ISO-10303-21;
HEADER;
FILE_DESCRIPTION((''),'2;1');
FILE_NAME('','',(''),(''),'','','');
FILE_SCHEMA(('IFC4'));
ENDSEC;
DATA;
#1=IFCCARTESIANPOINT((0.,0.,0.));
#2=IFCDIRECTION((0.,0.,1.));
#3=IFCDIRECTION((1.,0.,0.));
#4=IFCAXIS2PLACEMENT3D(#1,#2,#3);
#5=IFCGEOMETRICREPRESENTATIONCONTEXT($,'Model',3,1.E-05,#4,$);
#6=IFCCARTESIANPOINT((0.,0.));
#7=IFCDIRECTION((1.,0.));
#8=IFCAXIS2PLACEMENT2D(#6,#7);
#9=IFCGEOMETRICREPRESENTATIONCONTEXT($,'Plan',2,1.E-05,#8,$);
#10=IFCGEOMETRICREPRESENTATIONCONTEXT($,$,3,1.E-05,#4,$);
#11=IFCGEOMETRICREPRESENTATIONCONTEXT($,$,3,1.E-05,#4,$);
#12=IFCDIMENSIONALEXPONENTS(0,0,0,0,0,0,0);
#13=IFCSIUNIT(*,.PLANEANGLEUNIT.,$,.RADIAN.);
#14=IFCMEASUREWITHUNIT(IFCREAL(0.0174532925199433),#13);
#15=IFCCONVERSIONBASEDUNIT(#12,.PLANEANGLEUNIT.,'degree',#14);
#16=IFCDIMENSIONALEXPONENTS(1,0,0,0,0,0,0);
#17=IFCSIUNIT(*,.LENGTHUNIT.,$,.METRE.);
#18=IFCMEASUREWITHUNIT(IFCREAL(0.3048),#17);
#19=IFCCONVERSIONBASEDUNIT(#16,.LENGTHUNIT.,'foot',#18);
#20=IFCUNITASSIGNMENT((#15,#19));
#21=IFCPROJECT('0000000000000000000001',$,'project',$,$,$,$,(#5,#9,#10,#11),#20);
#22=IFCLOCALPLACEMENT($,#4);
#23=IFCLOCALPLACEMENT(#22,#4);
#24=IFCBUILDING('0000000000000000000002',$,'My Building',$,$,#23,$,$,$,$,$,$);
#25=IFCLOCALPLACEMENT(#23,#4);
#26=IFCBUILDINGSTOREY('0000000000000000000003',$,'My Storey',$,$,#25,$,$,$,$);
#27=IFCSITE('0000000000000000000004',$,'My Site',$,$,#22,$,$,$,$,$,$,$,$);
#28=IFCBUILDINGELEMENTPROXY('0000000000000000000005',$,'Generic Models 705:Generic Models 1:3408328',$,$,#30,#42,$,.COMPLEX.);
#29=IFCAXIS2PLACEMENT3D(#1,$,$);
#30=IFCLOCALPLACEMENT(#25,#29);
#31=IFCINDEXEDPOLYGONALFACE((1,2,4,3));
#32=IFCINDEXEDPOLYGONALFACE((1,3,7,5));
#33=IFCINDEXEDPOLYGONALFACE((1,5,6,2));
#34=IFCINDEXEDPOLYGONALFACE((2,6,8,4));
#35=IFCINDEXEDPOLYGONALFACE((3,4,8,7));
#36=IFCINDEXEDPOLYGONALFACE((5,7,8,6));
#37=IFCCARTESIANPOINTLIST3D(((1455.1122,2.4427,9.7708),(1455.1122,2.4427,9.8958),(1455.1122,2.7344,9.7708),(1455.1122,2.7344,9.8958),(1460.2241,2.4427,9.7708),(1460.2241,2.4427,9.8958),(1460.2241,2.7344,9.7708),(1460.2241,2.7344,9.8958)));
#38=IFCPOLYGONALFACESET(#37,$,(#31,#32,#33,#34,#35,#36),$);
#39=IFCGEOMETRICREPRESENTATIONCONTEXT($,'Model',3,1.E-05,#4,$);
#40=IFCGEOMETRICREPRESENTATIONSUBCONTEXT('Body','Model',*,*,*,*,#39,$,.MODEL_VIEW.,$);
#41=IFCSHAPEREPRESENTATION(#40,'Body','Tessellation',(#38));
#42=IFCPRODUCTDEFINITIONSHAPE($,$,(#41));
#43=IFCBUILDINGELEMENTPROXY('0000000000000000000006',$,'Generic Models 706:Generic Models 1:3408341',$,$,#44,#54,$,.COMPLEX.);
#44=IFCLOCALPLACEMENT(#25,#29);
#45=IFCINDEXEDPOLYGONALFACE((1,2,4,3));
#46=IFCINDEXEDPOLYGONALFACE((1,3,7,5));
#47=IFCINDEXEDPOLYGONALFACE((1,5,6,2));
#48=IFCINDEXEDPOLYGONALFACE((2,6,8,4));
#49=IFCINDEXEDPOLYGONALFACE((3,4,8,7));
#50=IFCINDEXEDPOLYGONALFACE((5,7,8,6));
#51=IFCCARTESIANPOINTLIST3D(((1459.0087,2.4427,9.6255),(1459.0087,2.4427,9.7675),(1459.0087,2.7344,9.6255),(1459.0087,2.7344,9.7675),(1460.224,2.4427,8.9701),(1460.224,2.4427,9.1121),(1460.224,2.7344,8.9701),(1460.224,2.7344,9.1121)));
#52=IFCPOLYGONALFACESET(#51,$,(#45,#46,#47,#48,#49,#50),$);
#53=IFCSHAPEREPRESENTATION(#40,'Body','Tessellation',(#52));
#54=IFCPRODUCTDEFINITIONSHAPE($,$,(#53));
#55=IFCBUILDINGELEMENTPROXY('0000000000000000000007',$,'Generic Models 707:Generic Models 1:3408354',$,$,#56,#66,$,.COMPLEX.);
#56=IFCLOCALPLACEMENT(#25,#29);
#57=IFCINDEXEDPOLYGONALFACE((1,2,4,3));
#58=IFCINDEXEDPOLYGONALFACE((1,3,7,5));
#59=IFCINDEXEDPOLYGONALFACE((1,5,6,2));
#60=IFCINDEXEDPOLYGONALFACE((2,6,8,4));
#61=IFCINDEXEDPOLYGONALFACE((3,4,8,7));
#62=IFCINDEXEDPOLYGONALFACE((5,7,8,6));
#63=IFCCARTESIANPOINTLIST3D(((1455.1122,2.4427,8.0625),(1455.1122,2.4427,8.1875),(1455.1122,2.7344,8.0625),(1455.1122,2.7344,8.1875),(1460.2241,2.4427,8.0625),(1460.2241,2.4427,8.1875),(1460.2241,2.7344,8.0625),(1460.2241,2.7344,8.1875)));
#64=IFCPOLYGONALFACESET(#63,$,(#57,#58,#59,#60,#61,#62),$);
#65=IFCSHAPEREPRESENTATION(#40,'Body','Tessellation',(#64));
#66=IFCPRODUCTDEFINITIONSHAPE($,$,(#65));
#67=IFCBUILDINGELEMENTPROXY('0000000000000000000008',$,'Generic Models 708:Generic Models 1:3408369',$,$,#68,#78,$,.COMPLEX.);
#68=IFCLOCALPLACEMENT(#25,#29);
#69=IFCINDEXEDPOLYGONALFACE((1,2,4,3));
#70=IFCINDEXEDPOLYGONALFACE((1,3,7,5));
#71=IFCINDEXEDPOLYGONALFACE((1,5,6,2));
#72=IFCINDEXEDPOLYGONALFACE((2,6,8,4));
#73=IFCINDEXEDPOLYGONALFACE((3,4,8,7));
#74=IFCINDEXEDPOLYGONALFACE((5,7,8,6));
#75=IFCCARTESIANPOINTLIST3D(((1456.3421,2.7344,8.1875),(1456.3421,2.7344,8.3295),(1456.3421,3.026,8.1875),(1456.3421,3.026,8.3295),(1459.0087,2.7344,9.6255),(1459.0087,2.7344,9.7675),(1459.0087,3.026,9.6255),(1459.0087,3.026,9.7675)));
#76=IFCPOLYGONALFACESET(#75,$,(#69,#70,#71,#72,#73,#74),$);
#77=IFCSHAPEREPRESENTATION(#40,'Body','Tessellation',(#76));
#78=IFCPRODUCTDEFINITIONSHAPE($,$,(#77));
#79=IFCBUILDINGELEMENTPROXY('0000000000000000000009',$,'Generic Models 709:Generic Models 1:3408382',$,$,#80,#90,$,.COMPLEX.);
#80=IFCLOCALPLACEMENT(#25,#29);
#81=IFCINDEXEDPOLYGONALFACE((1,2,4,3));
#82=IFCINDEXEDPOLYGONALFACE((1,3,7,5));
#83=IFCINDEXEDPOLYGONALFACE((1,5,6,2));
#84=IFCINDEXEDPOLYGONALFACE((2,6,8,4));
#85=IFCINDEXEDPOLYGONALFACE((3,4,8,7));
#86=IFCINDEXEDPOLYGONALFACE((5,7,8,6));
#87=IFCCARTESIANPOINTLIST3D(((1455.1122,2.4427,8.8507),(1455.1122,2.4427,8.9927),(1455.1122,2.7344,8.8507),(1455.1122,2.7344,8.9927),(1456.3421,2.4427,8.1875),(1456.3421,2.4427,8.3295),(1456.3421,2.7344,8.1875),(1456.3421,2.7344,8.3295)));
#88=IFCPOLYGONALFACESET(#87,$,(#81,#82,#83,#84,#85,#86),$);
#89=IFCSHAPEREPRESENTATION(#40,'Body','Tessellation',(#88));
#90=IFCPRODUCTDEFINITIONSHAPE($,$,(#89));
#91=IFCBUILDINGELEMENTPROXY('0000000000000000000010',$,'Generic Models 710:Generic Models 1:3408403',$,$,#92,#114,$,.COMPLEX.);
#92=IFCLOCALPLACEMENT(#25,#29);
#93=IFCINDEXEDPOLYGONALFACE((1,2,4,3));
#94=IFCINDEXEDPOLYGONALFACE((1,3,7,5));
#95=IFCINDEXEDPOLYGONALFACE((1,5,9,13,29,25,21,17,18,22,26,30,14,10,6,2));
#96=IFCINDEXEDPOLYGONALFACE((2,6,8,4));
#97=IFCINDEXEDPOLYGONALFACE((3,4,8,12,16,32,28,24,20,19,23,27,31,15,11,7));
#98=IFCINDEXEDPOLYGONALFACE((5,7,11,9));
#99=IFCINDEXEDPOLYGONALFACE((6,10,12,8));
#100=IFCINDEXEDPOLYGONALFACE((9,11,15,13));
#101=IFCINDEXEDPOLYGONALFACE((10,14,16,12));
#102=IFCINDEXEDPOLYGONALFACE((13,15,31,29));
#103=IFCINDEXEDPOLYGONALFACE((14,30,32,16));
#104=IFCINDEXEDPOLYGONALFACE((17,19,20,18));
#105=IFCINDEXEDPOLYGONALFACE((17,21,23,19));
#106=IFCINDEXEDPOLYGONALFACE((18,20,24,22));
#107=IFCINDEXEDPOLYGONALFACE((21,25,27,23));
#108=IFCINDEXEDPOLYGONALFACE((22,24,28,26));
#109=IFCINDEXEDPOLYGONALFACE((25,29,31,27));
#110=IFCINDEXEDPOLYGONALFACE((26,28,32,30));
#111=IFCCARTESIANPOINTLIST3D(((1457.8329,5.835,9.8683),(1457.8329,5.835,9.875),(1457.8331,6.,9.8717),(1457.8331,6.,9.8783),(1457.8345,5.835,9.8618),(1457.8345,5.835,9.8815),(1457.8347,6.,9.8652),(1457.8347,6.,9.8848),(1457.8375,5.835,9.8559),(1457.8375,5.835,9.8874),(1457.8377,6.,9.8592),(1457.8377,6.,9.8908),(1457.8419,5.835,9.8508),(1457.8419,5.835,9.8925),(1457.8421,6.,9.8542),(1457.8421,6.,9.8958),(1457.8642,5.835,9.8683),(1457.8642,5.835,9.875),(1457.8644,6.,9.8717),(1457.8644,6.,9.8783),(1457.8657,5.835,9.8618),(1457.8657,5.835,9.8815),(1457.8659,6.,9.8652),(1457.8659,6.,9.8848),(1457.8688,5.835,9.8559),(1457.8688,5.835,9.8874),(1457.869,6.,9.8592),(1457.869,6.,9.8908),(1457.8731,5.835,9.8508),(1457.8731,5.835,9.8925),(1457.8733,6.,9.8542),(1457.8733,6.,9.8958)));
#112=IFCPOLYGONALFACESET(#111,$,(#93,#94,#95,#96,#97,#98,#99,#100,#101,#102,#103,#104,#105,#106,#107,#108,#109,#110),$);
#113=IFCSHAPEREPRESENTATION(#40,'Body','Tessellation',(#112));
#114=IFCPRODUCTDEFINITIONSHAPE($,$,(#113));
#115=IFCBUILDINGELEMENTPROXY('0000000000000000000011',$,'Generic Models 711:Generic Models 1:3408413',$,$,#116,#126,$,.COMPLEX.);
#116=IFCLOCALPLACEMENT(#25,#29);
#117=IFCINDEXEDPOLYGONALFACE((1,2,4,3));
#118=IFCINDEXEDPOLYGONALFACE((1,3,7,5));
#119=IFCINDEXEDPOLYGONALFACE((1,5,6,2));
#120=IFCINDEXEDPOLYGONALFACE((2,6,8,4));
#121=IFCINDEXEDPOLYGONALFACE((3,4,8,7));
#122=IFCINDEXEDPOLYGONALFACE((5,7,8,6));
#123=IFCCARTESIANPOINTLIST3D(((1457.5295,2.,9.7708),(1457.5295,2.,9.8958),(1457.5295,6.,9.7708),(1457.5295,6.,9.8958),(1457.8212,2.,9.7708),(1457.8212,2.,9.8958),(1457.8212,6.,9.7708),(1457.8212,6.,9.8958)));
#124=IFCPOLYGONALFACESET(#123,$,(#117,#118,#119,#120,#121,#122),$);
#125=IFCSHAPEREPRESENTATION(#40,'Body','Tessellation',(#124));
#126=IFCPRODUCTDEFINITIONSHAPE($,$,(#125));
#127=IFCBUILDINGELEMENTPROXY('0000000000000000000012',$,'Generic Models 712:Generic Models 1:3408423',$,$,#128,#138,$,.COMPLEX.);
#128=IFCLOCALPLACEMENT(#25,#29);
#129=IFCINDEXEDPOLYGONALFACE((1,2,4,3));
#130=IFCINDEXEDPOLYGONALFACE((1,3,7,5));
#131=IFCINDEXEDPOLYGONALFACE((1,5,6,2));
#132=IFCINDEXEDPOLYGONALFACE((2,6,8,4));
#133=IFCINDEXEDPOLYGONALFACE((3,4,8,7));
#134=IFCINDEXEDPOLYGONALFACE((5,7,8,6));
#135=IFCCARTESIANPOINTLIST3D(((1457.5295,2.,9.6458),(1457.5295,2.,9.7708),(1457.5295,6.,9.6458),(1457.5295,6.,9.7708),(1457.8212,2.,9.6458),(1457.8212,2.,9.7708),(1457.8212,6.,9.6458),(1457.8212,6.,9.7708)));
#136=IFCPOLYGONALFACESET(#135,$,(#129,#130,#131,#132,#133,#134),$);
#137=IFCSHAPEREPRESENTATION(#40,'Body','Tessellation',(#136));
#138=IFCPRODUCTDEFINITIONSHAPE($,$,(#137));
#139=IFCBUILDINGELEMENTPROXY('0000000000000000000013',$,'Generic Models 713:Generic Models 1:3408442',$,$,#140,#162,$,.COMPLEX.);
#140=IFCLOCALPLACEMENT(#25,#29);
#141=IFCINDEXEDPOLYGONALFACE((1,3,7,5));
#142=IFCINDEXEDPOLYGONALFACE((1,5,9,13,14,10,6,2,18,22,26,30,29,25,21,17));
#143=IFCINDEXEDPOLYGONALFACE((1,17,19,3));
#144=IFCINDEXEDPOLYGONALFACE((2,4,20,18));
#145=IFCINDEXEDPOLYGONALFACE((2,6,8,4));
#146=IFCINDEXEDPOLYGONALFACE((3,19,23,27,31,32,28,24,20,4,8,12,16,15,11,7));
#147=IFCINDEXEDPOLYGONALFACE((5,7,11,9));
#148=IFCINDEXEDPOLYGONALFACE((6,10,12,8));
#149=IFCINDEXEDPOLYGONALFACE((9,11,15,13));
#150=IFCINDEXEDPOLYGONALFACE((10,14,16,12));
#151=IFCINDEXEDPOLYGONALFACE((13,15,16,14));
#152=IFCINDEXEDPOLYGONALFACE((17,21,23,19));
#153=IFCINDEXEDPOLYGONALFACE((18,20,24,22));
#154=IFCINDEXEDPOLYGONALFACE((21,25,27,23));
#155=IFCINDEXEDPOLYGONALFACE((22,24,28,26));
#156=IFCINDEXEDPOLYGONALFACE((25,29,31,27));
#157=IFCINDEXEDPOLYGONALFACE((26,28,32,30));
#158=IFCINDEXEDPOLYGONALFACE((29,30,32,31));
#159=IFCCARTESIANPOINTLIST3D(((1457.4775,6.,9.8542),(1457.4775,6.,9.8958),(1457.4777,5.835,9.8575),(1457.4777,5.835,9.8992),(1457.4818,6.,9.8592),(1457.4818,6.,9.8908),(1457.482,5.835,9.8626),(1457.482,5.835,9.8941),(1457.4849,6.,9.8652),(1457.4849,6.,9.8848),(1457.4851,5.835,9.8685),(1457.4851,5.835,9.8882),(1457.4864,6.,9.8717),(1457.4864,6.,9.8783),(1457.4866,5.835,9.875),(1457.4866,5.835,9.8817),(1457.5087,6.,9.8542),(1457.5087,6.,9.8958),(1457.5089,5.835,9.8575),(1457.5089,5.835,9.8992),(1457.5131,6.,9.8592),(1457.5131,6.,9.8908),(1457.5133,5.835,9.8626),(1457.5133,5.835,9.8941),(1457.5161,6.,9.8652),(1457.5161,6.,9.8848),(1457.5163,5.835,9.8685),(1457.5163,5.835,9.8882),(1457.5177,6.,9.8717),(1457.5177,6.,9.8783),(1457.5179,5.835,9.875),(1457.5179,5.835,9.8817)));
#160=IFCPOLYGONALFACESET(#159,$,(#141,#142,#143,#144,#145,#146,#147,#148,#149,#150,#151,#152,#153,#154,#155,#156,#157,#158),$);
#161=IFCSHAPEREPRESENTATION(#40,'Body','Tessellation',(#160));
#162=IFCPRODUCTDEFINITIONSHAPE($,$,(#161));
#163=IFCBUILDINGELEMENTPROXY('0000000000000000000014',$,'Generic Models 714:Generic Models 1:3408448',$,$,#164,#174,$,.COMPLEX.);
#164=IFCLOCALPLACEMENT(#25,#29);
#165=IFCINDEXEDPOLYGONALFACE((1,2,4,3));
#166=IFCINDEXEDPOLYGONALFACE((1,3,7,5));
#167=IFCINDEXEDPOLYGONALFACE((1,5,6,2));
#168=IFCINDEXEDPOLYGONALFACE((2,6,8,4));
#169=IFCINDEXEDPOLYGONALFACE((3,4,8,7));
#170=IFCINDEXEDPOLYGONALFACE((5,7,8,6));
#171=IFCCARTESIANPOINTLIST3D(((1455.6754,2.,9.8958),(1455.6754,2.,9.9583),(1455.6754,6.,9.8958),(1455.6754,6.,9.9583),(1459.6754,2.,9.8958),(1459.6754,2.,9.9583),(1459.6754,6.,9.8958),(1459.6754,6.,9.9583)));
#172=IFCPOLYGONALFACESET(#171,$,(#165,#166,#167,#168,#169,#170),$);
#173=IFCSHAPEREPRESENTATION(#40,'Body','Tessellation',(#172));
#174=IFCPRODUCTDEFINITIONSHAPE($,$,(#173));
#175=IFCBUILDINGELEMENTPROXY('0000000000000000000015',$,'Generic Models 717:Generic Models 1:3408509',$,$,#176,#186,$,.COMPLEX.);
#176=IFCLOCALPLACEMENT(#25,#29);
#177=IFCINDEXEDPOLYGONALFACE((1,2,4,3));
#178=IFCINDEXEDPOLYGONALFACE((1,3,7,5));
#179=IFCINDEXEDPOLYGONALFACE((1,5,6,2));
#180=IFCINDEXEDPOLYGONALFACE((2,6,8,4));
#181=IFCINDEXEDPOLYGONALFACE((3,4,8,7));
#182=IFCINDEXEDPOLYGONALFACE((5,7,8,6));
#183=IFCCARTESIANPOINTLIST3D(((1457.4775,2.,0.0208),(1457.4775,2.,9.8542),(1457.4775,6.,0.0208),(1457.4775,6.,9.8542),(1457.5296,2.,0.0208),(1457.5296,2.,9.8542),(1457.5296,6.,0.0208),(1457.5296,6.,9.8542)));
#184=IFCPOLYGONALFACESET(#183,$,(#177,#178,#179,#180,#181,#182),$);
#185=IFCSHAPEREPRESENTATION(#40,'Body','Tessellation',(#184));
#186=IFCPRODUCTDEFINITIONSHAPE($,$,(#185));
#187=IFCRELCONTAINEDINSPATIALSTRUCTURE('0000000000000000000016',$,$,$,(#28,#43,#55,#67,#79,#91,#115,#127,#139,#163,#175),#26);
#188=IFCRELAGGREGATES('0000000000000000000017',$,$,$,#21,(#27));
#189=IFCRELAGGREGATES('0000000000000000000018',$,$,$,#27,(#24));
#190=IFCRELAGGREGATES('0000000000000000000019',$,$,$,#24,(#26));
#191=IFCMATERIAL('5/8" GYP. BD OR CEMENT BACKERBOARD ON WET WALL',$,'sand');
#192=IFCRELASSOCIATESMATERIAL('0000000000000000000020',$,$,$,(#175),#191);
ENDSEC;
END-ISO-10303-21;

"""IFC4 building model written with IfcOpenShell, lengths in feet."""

from ifc_helpers import new_model, entity, si_unit, converted_unit, frame, origin_with_axes, origin_2d_with_axis, place, context, subcontext, project, spatial, polyline, outline, extrude, material, element, save


model = new_model("IFC4")

# Units and contexts
model_context_1 = context("Model", 3, precision=1e-05, world=origin_with_axes())
plan_context = context("Plan", 2, precision=1e-05, world=origin_2d_with_axis())
model_context_2 = context("Model", 3, precision=1e-05, world=origin_with_axes())
context_of_model_1 = context(None, 3, precision=1e-05, world=origin_with_axes())
context_of_model_2 = context(None, 3, precision=1e-05, world=origin_with_axes())
body_context = subcontext(model_context_2, "Body", "Model", "MODEL_VIEW")
ifc_project = project(units=[converted_unit("PLANEANGLEUNIT", "degree", entity("IfcReal", 0.0174532925199433), si_unit("PLANEANGLEUNIT", "RADIAN"), dimensions=[0, 0, 0, 0, 0, 0, 0]), converted_unit("LENGTHUNIT", "foot", entity("IfcReal", 0.3048), si_unit("LENGTHUNIT", "METRE"), dimensions=[1, 0, 0, 0, 0, 0, 0])], contexts=[model_context_1, plan_context, context_of_model_1, context_of_model_2])

# Site, building, storey
site_placement = place(None, origin_with_axes())
site = spatial("IfcSite", under=ifc_project, at=site_placement, Name="My Site")
building_placement = place(site_placement, origin_with_axes())
building = spatial("IfcBuilding", under=site, at=building_placement, Name="My Building")
storey_placement = place(building_placement, origin_with_axes())
storey = spatial("IfcBuildingStorey", under=building, at=storey_placement, Name="My Storey")

# Building element proxies
ifc_material_1 = material(Name="5/8\" GYP. BD OR CEMENT BACKERBOARD ON WET WALL", Category="sand")
proxy_1_placement = place(storey_placement, frame((1455.1122, 2.7344, 9.7708), z_axis=(0.0, -1.0, 0.0), x_axis=(1.0, 0.0, 0.0)))
element("IfcBuildingElementProxy", 1, at=proxy_1_placement, inside=storey, Name="Generic Models 705:Generic Models 1:3408328", PredefinedType="COMPLEX", context=body_context, shape_type="SweptSolid", body=[
    extrude(outline(polyline([(-0.0625, -2.556), (0.0625, -2.556), (0.0625, 2.556), (-0.0625, 2.556), (-0.0625, -2.556)])), frame((2.556, 0.0625, 0.0), z_axis=(0.0, 0.0, -1.0), x_axis=(0.0, 1.0, 0.0)), (0.0, 0.0, -1.0), 0.2917),
])
proxy_2_placement = place(storey_placement, frame((1459.0087, 2.7344, 8.9701), z_axis=(0.0, -1.0, 0.0), x_axis=(1.0, 0.0, 0.0)))
element("IfcBuildingElementProxy", 2, at=proxy_2_placement, inside=storey, Name="Generic Models 706:Generic Models 1:3408341", PredefinedType="COMPLEX", context=body_context, shape_type="SweptSolid", body=[
    extrude(outline(polyline([(0.2567, -0.6077), (0.3987, -0.6077), (-0.2567, 0.6077), (-0.3987, 0.6077), (0.2567, -0.6077)])), frame((0.6077, 0.3987, 0.0), z_axis=(0.0, 0.0, -1.0), x_axis=(0.0, 1.0, 0.0)), (0.0, 0.0, -1.0), 0.2917),
])
proxy_3_placement = place(storey_placement, frame((1455.1122, 2.7344, 8.0625), z_axis=(0.0, -1.0, 0.0), x_axis=(1.0, 0.0, 0.0)))
element("IfcBuildingElementProxy", 3, at=proxy_3_placement, inside=storey, Name="Generic Models 707:Generic Models 1:3408354", PredefinedType="COMPLEX", context=body_context, shape_type="SweptSolid", body=[
    extrude(outline(polyline([(-0.0625, -2.556), (0.0625, -2.556), (0.0625, 2.556), (-0.0625, 2.556), (-0.0625, -2.556)])), frame((2.556, 0.0625, 0.0), z_axis=(0.0, 0.0, -1.0), x_axis=(0.0, 1.0, 0.0)), (0.0, 0.0, -1.0), 0.2917),
])
proxy_4_placement = place(storey_placement, frame((1456.3421, 3.026, 8.1875), z_axis=(0.0, -1.0, 0.0), x_axis=(1.0, 0.0, 0.0)))
element("IfcBuildingElementProxy", 4, at=proxy_4_placement, inside=storey, Name="Generic Models 708:Generic Models 1:3408369", PredefinedType="COMPLEX", context=body_context, shape_type="SweptSolid", body=[
    extrude(outline(polyline([(-0.79, -1.3333), (-0.648, -1.3333), (0.79, 1.3333), (0.648, 1.3333), (-0.79, -1.3333)])), frame((1.3333, 0.79, 0.0), z_axis=(0.0, 0.0, -1.0), x_axis=(0.0, -1.0, 0.0)), (0.0, 0.0, -1.0), 0.2917),
])
proxy_5_placement = place(storey_placement, frame((1455.1122, 2.7344, 8.1875), z_axis=(0.0, -1.0, 0.0), x_axis=(1.0, 0.0, 0.0)))
element("IfcBuildingElementProxy", 5, at=proxy_5_placement, inside=storey, Name="Generic Models 709:Generic Models 1:3408382", PredefinedType="COMPLEX", context=body_context, shape_type="SweptSolid", body=[
    extrude(outline(polyline([(0.2606, -0.6149), (0.4026, -0.6149), (-0.2606, 0.6149), (-0.4026, 0.6149), (0.2606, -0.6149)])), frame((0.6149, 0.4026, 0.0), z_axis=(0.0, 0.0, -1.0), x_axis=(0.0, 1.0, 0.0)), (0.0, 0.0, -1.0), 0.2917),
])
proxy_6_placement = place(storey_placement, frame((1457.8331, 6.0, 9.8542), z_axis=(0.0, -1.0, 0.0), x_axis=(0.0, 0.0, 1.0)))
element("IfcBuildingElementProxy", 6, at=proxy_6_placement, inside=storey, Name="Generic Models 710:Generic Models 1:3408403", PredefinedType="COMPLEX", context=body_context, shape_type="SweptSolid", body=[
    extrude(outline(polyline([(0.0166, 0.0), (0.0115, 0.0043), (0.0076, 0.0097), (0.005, 0.0159), (0.0039, 0.0224), (0.0045, 0.0291), (-0.0207, 0.0106), (-0.0213, 0.004), (-0.0202, -0.0026), (-0.0176, -0.0088), (-0.0137, -0.0142), (-0.0086, -0.0185), (-0.0026, -0.0215), (0.0039, -0.023), (0.0291, -0.0045), (0.0226, -0.003), (0.0166, 0.0)])), frame((0.0208, -0.0194, 0.0), z_axis=(0.0, 0.0, -1.0), x_axis=(0.591192, -0.806531, 0.0)), (-0.012926, 0.015608, -0.999795), 0.165),
])
proxy_7_placement = place(storey_placement, frame((1457.5295, 6.0, 9.7708), z_axis=(0.0, -1.0, 0.0), x_axis=(0.0, 0.0, 1.0)))
element("IfcBuildingElementProxy", 7, at=proxy_7_placement, inside=storey, Name="Generic Models 711:Generic Models 1:3408413", PredefinedType="COMPLEX", context=body_context, shape_type="SweptSolid", body=[
    extrude(outline(polyline([(-0.0625, -0.1458), (0.0625, -0.1458), (0.0625, 0.1458), (-0.0625, 0.1458), (-0.0625, -0.1458)])), frame((0.0625, -0.1458, 0.0), z_axis=(0.0, 0.0, -1.0), x_axis=(-1.0, 0.0, 0.0)), (0.0, 0.0, -1.0), 4.0),
])
proxy_8_placement = place(storey_placement, frame((1457.5295, 6.0, 9.6458), z_axis=(0.0, -1.0, 0.0), x_axis=(0.0, 0.0, 1.0)))
element("IfcBuildingElementProxy", 8, at=proxy_8_placement, inside=storey, Name="Generic Models 712:Generic Models 1:3408423", PredefinedType="COMPLEX", context=body_context, shape_type="SweptSolid", body=[
    extrude(outline(polyline([(-0.0625, -0.1458), (0.0625, -0.1458), (0.0625, 0.1458), (-0.0625, 0.1458), (-0.0625, -0.1458)])), frame((0.0625, -0.1458, 0.0), z_axis=(0.0, 0.0, -1.0), x_axis=(1.0, 0.0, 0.0)), (0.0, 0.0, -1.0), 4.0),
])
proxy_9_placement = place(storey_placement, frame((1457.4775, 6.0, 9.8542), z_axis=(0.0, -1.0, 0.0), x_axis=(0.0, 0.0, 1.0)))
element("IfcBuildingElementProxy", 9, at=proxy_9_placement, inside=storey, Name="Generic Models 713:Generic Models 1:3408442", PredefinedType="COMPLEX", context=body_context, shape_type="SweptSolid", body=[
    extrude(outline(polyline([(0.0166, 0.0), (0.0226, 0.003), (0.0291, 0.0045), (0.0039, 0.023), (-0.0026, 0.0215), (-0.0086, 0.0185), (-0.0137, 0.0142), (-0.0176, 0.0088), (-0.0202, 0.0026), (-0.0213, -0.004), (-0.0207, -0.0106), (0.0045, -0.0291), (0.0039, -0.0224), (0.005, -0.0159), (0.0076, -0.0097), (0.0115, -0.0043), (0.0166, 0.0)])), frame((0.0208, -0.0208, 0.0), z_axis=(0.0, 0.0, -1.0), x_axis=(0.591192, 0.806531, 0.0)), (0.010994, 0.017024, -0.999795), 0.165),
])
proxy_10_placement = place(storey_placement, frame((1455.6754, 6.0, 9.8958), z_axis=(0.0, -1.0, 0.0), x_axis=(0.0, 0.0, 1.0)))
element("IfcBuildingElementProxy", 10, at=proxy_10_placement, inside=storey, Name="Generic Models 714:Generic Models 1:3408448", PredefinedType="COMPLEX", context=body_context, shape_type="SweptSolid", body=[
    extrude(outline(polyline([(-0.0313, -2.0), (0.0312, -2.0), (0.0313, 2.0), (-0.0312, 2.0), (-0.0313, -2.0)])), frame((0.0313, -2.0, 0.0), z_axis=(0.0, 0.0, -1.0), x_axis=(-1.0, 0.0, 0.0)), (0.0, 0.0, -1.0), 4.0),
])
proxy_11_placement = place(storey_placement, frame((1457.4775, 6.0, 0.0208), z_axis=(0.0, -1.0, 0.0), x_axis=(0.0, 0.0, 1.0)))
element("IfcBuildingElementProxy", 11, at=proxy_11_placement, inside=storey, material=ifc_material_1, Name="Generic Models 717:Generic Models 1:3408509", PredefinedType="COMPLEX", context=body_context, shape_type="SweptSolid", body=[
    extrude(outline(polyline([(-0.026, -4.9167), (0.026, -4.9167), (0.026, 4.9167), (-0.026, 4.9167), (-0.026, -4.9167)])), frame((4.9167, -0.026, 0.0), z_axis=(0.0, 0.0, -1.0), x_axis=(0.0, -1.0, 0.0)), (0.0, 0.0, -1.0), 4.0),
])

save(model, "model.ifc")
